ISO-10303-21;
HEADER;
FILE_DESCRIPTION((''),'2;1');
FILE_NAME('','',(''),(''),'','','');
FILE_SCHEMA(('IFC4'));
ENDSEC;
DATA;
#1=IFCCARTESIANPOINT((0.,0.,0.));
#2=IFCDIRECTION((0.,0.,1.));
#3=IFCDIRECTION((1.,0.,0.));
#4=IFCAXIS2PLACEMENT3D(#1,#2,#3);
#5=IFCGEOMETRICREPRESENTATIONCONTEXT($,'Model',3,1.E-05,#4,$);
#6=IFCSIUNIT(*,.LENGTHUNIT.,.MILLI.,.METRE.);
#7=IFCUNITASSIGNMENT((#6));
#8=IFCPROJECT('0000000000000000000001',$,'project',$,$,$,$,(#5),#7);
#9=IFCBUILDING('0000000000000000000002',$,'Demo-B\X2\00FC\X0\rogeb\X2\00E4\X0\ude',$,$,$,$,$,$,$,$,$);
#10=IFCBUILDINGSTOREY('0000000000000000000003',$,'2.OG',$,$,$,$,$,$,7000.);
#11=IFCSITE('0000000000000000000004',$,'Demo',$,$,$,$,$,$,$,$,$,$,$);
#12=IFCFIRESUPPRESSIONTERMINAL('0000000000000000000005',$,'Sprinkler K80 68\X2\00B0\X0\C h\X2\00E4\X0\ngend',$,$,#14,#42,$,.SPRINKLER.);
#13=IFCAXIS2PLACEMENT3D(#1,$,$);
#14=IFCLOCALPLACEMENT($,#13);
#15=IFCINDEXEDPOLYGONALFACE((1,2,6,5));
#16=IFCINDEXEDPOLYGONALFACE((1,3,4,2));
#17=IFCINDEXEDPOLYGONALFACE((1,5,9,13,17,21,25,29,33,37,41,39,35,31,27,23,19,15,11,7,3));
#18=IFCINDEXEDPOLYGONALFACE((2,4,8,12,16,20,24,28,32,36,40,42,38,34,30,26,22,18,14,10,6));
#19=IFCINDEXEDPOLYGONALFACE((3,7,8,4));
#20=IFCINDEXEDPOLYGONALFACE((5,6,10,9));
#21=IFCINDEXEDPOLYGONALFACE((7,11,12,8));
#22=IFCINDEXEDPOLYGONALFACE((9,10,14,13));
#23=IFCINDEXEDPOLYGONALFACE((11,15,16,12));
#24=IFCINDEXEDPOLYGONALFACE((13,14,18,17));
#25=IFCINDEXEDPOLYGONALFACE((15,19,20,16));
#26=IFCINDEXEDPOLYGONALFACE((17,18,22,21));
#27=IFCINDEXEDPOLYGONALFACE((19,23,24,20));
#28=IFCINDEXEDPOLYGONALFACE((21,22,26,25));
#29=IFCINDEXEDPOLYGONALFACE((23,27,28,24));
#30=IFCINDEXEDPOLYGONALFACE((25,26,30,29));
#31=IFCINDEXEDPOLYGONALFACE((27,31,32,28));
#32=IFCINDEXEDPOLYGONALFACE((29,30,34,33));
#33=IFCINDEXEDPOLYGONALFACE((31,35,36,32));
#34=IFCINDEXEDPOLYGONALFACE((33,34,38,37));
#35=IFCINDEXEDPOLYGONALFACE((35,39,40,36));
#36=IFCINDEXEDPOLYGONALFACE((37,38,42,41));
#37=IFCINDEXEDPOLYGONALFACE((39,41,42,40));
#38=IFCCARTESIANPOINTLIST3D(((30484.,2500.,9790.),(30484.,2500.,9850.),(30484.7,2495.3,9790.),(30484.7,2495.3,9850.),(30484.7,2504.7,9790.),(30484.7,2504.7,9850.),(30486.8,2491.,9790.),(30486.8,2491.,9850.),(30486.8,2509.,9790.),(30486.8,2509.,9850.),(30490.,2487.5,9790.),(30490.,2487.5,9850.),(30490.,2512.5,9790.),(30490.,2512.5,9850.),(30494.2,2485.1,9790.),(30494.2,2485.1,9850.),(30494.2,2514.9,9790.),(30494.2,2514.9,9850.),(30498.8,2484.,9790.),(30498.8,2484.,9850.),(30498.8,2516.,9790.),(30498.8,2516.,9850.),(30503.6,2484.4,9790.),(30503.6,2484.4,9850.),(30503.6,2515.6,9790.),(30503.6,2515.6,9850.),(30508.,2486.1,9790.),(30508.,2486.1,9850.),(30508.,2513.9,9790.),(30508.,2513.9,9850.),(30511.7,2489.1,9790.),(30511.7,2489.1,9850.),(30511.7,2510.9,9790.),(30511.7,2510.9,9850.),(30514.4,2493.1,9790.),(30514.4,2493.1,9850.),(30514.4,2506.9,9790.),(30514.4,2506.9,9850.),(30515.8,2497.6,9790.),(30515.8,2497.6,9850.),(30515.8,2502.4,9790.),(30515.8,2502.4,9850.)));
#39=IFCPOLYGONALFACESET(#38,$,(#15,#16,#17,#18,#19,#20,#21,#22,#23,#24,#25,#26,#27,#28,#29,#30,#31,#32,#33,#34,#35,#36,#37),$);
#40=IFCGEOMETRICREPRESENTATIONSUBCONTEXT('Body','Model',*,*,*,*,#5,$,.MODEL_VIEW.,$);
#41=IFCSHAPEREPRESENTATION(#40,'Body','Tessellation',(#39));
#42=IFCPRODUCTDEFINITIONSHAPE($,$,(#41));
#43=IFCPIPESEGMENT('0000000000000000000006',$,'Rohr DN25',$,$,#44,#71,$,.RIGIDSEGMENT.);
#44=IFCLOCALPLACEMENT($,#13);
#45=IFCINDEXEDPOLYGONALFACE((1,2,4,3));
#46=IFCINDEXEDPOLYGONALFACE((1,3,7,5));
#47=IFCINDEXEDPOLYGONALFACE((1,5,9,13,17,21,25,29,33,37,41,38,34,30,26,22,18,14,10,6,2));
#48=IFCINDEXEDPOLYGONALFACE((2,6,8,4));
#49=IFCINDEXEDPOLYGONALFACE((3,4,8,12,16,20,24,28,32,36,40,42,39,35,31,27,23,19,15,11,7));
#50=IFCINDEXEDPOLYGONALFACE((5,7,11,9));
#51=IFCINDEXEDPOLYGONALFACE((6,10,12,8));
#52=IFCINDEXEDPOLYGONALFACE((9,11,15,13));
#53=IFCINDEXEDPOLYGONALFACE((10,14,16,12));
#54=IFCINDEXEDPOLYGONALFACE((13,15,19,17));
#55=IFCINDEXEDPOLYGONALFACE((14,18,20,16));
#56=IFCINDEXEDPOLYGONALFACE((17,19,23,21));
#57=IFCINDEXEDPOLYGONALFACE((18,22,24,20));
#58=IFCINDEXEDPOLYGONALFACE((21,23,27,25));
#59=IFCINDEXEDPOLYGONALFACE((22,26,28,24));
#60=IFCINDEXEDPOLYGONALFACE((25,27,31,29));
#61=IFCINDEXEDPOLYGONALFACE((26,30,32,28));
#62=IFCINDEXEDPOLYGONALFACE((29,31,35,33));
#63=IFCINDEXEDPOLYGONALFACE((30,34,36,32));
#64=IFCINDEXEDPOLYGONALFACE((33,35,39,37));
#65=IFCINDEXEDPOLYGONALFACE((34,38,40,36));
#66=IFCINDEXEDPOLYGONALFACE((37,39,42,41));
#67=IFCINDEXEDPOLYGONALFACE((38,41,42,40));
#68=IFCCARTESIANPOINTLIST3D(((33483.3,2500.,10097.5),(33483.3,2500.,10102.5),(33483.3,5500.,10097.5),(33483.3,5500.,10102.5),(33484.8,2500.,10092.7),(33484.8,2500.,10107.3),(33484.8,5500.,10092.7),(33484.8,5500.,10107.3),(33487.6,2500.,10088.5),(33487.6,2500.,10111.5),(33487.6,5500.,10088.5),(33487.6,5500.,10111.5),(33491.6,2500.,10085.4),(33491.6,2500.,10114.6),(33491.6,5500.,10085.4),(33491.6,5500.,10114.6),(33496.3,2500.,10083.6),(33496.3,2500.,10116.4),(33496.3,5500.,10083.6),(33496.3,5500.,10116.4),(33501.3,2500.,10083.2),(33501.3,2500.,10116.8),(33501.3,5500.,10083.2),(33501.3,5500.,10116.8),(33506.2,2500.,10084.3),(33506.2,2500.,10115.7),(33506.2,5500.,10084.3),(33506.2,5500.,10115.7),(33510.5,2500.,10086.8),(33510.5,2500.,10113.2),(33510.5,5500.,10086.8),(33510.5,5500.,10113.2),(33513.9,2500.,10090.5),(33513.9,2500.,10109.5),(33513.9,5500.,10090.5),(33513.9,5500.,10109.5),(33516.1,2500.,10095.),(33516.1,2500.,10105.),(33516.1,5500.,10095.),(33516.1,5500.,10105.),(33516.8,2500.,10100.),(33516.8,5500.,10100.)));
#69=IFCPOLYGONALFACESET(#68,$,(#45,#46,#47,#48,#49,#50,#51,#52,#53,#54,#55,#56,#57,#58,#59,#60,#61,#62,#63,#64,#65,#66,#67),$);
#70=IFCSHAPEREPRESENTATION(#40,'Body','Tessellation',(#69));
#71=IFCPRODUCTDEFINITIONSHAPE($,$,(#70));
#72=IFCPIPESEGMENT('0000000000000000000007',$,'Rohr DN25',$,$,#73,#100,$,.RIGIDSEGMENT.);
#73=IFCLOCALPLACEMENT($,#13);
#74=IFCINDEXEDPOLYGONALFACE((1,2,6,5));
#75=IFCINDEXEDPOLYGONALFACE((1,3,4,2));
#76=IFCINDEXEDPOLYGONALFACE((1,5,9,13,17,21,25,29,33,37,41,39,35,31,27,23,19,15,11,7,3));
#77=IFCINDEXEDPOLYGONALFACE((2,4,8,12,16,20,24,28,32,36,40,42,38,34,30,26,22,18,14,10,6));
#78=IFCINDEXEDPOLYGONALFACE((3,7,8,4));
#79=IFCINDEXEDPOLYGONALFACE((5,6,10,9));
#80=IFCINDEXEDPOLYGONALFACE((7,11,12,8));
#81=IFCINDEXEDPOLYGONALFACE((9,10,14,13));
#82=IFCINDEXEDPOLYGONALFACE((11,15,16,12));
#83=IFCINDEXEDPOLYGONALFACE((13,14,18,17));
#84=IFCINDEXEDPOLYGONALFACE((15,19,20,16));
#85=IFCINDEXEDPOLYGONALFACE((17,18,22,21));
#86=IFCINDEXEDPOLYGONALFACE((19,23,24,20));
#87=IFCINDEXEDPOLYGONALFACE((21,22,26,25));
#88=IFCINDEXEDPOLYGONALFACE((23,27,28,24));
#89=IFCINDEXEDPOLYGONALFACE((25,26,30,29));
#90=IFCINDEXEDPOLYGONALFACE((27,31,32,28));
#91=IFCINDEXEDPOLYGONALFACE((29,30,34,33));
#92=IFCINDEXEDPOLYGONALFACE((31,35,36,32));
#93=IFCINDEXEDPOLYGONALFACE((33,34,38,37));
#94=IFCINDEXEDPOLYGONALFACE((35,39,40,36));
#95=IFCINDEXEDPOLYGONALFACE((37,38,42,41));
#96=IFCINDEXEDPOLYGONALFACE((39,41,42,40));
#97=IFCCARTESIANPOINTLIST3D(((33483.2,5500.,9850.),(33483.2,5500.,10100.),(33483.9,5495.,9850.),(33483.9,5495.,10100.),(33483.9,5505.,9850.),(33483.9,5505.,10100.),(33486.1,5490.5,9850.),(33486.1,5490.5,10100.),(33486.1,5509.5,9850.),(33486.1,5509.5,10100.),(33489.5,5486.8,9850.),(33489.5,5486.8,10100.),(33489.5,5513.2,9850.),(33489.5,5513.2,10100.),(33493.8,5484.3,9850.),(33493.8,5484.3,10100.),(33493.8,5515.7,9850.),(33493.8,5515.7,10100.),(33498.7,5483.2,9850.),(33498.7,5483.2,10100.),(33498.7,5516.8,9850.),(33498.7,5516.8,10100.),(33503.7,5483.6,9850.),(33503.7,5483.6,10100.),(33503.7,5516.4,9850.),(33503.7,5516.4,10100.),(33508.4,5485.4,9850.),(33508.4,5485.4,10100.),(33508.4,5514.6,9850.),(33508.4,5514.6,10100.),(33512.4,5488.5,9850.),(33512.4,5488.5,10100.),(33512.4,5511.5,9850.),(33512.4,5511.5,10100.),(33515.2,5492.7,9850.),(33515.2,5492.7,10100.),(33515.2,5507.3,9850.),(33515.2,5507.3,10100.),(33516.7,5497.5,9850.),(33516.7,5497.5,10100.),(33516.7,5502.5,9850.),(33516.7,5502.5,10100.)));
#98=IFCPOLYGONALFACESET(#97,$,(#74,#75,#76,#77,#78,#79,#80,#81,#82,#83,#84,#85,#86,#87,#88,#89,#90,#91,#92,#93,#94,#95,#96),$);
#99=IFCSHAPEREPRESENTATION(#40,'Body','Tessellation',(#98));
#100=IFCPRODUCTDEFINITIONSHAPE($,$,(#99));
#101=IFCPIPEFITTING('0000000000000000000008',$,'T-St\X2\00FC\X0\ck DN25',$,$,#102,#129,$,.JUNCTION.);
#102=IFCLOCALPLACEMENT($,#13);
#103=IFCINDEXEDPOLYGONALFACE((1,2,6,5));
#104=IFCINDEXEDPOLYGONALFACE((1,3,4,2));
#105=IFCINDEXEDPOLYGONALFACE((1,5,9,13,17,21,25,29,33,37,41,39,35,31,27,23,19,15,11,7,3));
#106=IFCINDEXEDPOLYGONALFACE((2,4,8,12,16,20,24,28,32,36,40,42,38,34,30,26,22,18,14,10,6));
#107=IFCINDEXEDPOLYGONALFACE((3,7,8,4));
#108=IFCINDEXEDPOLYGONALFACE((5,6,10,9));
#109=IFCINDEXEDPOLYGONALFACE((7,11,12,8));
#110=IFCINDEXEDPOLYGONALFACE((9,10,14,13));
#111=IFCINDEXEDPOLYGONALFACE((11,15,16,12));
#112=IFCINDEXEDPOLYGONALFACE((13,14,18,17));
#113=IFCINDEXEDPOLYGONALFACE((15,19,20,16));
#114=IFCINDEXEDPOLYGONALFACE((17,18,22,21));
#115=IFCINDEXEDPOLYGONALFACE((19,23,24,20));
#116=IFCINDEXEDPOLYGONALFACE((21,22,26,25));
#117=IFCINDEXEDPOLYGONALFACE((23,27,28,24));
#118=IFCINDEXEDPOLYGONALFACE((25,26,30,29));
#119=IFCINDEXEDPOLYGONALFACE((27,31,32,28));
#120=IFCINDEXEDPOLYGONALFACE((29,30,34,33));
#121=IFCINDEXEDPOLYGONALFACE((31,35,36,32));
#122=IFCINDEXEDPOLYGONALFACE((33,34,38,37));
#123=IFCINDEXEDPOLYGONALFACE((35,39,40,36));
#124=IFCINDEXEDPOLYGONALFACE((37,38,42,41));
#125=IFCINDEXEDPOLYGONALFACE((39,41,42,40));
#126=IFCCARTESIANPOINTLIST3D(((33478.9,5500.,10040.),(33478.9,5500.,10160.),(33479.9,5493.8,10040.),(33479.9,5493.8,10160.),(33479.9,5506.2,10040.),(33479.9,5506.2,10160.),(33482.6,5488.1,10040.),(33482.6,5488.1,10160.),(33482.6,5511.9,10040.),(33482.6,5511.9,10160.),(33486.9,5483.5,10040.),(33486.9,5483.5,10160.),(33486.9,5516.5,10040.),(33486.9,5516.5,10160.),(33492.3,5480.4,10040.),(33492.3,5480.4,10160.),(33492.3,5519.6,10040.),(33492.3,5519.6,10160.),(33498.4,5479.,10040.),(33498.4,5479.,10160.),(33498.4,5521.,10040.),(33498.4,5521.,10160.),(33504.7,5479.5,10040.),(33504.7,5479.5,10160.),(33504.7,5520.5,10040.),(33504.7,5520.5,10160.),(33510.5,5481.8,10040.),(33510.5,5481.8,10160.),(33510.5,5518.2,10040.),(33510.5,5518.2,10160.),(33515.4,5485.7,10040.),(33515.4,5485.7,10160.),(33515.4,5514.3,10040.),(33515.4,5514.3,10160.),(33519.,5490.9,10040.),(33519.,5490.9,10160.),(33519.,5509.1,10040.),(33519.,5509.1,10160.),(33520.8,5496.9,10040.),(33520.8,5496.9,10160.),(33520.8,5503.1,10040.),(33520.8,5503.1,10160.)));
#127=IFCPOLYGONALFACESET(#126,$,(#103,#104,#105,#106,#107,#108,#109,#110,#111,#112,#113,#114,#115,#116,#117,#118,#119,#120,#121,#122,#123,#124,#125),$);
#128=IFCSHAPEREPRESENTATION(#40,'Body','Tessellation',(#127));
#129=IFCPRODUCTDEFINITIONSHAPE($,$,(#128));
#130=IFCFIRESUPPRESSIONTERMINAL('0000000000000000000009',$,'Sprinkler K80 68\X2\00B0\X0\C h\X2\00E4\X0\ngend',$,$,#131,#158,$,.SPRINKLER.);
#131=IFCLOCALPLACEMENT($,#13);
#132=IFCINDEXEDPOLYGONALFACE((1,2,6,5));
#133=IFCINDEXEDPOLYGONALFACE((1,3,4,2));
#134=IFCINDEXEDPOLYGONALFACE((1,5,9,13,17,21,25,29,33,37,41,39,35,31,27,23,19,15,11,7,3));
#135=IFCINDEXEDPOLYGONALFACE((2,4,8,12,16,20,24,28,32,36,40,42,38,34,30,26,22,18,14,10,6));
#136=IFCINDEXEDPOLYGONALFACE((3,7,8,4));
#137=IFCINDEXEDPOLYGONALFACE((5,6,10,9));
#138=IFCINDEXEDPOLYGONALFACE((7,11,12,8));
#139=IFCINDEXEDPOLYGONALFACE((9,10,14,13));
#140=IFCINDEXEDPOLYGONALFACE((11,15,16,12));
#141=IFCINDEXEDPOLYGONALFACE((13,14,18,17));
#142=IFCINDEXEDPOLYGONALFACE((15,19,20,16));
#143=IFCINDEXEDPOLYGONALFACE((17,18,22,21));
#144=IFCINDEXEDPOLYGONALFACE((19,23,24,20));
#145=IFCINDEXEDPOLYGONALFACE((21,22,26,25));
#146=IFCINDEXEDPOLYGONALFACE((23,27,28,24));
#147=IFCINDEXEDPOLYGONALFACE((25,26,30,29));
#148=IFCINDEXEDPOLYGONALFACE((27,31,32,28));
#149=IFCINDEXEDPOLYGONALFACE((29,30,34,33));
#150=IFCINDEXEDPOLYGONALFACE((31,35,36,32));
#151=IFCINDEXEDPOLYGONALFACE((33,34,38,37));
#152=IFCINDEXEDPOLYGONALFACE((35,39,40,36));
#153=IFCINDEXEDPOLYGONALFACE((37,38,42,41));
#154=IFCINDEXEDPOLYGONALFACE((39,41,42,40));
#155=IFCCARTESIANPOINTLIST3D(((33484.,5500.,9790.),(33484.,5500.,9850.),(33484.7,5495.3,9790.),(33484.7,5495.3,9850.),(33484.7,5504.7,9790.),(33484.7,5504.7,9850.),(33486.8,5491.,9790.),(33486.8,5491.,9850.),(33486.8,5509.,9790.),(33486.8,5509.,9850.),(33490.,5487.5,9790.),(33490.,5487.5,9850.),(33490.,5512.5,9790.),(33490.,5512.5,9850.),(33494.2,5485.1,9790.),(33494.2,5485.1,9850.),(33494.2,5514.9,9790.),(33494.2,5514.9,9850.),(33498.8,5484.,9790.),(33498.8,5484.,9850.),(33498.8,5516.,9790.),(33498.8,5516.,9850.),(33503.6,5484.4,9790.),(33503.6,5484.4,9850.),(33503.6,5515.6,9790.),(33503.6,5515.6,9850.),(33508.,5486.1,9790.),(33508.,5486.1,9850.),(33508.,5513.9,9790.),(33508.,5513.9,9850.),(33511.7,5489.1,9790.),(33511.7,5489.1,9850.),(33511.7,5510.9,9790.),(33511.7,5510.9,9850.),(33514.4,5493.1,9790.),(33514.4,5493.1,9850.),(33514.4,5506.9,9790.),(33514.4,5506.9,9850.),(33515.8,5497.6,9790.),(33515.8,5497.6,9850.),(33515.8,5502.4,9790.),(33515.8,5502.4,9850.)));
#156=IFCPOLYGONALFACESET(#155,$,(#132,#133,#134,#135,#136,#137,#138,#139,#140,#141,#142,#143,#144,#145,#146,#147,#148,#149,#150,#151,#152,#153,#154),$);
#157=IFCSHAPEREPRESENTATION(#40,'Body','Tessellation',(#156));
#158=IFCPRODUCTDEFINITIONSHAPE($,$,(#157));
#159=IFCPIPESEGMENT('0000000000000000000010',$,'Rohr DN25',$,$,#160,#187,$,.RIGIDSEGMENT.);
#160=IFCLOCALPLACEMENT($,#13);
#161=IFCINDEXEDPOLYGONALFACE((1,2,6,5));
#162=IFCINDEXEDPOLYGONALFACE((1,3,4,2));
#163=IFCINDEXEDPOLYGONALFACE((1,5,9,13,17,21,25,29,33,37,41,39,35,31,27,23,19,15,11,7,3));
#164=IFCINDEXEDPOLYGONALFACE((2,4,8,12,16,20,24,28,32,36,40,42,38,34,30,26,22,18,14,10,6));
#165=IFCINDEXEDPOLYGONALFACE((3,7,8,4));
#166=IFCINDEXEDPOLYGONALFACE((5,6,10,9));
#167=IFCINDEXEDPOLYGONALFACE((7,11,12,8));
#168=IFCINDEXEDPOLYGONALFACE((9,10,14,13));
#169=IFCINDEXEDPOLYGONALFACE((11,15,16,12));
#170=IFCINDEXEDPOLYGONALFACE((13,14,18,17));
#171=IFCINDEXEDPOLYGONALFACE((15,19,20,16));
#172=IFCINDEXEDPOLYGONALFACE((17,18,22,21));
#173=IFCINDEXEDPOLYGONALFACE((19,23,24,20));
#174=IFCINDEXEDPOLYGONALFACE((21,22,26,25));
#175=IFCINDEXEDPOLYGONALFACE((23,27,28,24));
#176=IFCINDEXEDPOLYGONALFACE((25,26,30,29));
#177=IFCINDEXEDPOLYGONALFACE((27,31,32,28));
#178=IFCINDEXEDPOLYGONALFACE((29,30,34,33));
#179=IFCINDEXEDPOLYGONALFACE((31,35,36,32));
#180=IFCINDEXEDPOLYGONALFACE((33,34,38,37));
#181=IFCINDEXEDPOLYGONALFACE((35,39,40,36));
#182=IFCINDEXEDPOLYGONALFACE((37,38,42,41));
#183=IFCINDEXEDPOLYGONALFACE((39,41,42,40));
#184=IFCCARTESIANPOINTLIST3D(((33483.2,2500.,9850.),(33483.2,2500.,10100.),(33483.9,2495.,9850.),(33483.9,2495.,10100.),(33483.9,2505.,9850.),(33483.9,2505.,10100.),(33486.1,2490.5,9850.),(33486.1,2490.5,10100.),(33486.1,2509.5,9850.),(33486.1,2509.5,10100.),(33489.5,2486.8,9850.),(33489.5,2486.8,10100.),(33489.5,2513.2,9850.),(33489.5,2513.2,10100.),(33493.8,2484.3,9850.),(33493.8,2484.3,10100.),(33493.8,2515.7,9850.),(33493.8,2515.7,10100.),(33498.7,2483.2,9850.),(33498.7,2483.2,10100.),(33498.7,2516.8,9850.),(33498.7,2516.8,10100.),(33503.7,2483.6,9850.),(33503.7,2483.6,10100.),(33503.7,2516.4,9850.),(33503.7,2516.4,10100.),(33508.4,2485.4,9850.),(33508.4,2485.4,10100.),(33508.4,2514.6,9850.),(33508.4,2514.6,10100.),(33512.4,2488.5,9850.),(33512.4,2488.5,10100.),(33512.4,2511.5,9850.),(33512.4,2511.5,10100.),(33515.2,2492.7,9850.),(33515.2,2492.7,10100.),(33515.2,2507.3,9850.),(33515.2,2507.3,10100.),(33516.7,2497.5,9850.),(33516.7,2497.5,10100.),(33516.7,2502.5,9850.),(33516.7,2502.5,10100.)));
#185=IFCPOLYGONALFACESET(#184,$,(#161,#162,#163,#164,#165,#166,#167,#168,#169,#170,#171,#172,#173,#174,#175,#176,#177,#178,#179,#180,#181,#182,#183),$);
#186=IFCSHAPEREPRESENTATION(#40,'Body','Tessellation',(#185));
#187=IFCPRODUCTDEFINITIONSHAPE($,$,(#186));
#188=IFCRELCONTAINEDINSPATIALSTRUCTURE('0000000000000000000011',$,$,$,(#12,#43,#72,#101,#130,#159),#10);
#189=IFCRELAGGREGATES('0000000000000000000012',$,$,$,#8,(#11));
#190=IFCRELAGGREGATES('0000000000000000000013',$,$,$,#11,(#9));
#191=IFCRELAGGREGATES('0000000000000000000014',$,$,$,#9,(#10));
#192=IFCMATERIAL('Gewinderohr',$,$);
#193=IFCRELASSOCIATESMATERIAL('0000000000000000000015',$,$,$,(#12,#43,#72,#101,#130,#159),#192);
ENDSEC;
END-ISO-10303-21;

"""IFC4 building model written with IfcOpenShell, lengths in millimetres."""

from ifc_helpers import new_model, si_unit, frame, origin_with_axes, place, context, subcontext, project, spatial, circle, extrude, material, element, save


model = new_model("IFC4")

# Units and contexts
model_context = context("Model", 3, precision=1e-05, world=origin_with_axes())
body_context = subcontext(model_context, "Body", "Model", "MODEL_VIEW")
ifc_project = project(units=[si_unit("LENGTHUNIT", "METRE", prefix="MILLI")], contexts=[model_context])

# Site, building, storey
site = spatial("IfcSite", under=ifc_project, Name="Demo")
building = spatial("IfcBuilding", under=site, Name="Demo-Bürogebäude")
storey = spatial("IfcBuildingStorey", under=building, Name="2.OG", Elevation=7000.0)

# Shared definitions
ifc_material_1 = material(Name="Gewinderohr")

# Fire suppression terminal
fire_suppression_terminal_1_placement = place(None, frame((30500.0, 2500.0, 9850.0), z_axis=(0.0, 0.0, -1.0), x_axis=(-1.0, 0.0, 0.0)))
element("IfcFireSuppressionTerminal", 1, at=fire_suppression_terminal_1_placement, inside=storey, material=ifc_material_1, Name="Sprinkler K80 68°C hängend", PredefinedType="SPRINKLER", context=body_context, shape_type="SweptSolid", body=[
    extrude(circle(Radius=16.0), origin_with_axes(), (0.0, 0.0, 1.0), 60.0),
])

# Pipe segments
pipe_segment_1_placement = place(None, frame((33500.0, 5500.0, 10100.0), z_axis=(0.0, -1.0, 0.0), x_axis=(1.0, 0.0, 0.0)))
element("IfcPipeSegment", 2, at=pipe_segment_1_placement, inside=storey, material=ifc_material_1, Name="Rohr DN25", PredefinedType="RIGIDSEGMENT", context=body_context, shape_type="SweptSolid", body=[
    extrude(circle(Radius=16.9), origin_with_axes(), (0.0, 0.0, 1.0), 3000.0),
])
pipe_segment_2_placement = place(None, frame((33500.0, 5500.0, 10100.0), z_axis=(0.0, 0.0, -1.0), x_axis=(-1.0, 0.0, 0.0)))
element("IfcPipeSegment", 3, at=pipe_segment_2_placement, inside=storey, material=ifc_material_1, Name="Rohr DN25", PredefinedType="RIGIDSEGMENT", context=body_context, shape_type="SweptSolid", body=[
    extrude(circle(Radius=16.9), origin_with_axes(), (0.0, 0.0, 1.0), 250.0),
])

# Pipe fitting
pipe_fitting_1_placement = place(None, frame((33500.0, 5500.0, 10160.0), z_axis=(0.0, 0.0, -1.0), x_axis=(-1.0, 0.0, 0.0)))
element("IfcPipeFitting", 4, at=pipe_fitting_1_placement, inside=storey, material=ifc_material_1, Name="T-Stück DN25", PredefinedType="JUNCTION", context=body_context, shape_type="SweptSolid", body=[
    extrude(circle(Radius=21.1), origin_with_axes(), (0.0, 0.0, 1.0), 120.0),
])

# Fire suppression terminal
fire_suppression_terminal_2_placement = place(None, frame((33500.0, 5500.0, 9850.0), z_axis=(0.0, 0.0, -1.0), x_axis=(-1.0, 0.0, 0.0)))
element("IfcFireSuppressionTerminal", 5, at=fire_suppression_terminal_2_placement, inside=storey, material=ifc_material_1, Name="Sprinkler K80 68°C hängend", PredefinedType="SPRINKLER", context=body_context, shape_type="SweptSolid", body=[
    extrude(circle(Radius=16.0), origin_with_axes(), (0.0, 0.0, 1.0), 60.0),
])

# Pipe segment
pipe_segment_3_placement = place(None, frame((33500.0, 2500.0, 10100.0), z_axis=(0.0, 0.0, -1.0), x_axis=(-1.0, 0.0, 0.0)))
element("IfcPipeSegment", 6, at=pipe_segment_3_placement, inside=storey, material=ifc_material_1, Name="Rohr DN25", PredefinedType="RIGIDSEGMENT", context=body_context, shape_type="SweptSolid", body=[
    extrude(circle(Radius=16.9), origin_with_axes(), (0.0, 0.0, 1.0), 250.0),
])

save(model, "model.ifc")
